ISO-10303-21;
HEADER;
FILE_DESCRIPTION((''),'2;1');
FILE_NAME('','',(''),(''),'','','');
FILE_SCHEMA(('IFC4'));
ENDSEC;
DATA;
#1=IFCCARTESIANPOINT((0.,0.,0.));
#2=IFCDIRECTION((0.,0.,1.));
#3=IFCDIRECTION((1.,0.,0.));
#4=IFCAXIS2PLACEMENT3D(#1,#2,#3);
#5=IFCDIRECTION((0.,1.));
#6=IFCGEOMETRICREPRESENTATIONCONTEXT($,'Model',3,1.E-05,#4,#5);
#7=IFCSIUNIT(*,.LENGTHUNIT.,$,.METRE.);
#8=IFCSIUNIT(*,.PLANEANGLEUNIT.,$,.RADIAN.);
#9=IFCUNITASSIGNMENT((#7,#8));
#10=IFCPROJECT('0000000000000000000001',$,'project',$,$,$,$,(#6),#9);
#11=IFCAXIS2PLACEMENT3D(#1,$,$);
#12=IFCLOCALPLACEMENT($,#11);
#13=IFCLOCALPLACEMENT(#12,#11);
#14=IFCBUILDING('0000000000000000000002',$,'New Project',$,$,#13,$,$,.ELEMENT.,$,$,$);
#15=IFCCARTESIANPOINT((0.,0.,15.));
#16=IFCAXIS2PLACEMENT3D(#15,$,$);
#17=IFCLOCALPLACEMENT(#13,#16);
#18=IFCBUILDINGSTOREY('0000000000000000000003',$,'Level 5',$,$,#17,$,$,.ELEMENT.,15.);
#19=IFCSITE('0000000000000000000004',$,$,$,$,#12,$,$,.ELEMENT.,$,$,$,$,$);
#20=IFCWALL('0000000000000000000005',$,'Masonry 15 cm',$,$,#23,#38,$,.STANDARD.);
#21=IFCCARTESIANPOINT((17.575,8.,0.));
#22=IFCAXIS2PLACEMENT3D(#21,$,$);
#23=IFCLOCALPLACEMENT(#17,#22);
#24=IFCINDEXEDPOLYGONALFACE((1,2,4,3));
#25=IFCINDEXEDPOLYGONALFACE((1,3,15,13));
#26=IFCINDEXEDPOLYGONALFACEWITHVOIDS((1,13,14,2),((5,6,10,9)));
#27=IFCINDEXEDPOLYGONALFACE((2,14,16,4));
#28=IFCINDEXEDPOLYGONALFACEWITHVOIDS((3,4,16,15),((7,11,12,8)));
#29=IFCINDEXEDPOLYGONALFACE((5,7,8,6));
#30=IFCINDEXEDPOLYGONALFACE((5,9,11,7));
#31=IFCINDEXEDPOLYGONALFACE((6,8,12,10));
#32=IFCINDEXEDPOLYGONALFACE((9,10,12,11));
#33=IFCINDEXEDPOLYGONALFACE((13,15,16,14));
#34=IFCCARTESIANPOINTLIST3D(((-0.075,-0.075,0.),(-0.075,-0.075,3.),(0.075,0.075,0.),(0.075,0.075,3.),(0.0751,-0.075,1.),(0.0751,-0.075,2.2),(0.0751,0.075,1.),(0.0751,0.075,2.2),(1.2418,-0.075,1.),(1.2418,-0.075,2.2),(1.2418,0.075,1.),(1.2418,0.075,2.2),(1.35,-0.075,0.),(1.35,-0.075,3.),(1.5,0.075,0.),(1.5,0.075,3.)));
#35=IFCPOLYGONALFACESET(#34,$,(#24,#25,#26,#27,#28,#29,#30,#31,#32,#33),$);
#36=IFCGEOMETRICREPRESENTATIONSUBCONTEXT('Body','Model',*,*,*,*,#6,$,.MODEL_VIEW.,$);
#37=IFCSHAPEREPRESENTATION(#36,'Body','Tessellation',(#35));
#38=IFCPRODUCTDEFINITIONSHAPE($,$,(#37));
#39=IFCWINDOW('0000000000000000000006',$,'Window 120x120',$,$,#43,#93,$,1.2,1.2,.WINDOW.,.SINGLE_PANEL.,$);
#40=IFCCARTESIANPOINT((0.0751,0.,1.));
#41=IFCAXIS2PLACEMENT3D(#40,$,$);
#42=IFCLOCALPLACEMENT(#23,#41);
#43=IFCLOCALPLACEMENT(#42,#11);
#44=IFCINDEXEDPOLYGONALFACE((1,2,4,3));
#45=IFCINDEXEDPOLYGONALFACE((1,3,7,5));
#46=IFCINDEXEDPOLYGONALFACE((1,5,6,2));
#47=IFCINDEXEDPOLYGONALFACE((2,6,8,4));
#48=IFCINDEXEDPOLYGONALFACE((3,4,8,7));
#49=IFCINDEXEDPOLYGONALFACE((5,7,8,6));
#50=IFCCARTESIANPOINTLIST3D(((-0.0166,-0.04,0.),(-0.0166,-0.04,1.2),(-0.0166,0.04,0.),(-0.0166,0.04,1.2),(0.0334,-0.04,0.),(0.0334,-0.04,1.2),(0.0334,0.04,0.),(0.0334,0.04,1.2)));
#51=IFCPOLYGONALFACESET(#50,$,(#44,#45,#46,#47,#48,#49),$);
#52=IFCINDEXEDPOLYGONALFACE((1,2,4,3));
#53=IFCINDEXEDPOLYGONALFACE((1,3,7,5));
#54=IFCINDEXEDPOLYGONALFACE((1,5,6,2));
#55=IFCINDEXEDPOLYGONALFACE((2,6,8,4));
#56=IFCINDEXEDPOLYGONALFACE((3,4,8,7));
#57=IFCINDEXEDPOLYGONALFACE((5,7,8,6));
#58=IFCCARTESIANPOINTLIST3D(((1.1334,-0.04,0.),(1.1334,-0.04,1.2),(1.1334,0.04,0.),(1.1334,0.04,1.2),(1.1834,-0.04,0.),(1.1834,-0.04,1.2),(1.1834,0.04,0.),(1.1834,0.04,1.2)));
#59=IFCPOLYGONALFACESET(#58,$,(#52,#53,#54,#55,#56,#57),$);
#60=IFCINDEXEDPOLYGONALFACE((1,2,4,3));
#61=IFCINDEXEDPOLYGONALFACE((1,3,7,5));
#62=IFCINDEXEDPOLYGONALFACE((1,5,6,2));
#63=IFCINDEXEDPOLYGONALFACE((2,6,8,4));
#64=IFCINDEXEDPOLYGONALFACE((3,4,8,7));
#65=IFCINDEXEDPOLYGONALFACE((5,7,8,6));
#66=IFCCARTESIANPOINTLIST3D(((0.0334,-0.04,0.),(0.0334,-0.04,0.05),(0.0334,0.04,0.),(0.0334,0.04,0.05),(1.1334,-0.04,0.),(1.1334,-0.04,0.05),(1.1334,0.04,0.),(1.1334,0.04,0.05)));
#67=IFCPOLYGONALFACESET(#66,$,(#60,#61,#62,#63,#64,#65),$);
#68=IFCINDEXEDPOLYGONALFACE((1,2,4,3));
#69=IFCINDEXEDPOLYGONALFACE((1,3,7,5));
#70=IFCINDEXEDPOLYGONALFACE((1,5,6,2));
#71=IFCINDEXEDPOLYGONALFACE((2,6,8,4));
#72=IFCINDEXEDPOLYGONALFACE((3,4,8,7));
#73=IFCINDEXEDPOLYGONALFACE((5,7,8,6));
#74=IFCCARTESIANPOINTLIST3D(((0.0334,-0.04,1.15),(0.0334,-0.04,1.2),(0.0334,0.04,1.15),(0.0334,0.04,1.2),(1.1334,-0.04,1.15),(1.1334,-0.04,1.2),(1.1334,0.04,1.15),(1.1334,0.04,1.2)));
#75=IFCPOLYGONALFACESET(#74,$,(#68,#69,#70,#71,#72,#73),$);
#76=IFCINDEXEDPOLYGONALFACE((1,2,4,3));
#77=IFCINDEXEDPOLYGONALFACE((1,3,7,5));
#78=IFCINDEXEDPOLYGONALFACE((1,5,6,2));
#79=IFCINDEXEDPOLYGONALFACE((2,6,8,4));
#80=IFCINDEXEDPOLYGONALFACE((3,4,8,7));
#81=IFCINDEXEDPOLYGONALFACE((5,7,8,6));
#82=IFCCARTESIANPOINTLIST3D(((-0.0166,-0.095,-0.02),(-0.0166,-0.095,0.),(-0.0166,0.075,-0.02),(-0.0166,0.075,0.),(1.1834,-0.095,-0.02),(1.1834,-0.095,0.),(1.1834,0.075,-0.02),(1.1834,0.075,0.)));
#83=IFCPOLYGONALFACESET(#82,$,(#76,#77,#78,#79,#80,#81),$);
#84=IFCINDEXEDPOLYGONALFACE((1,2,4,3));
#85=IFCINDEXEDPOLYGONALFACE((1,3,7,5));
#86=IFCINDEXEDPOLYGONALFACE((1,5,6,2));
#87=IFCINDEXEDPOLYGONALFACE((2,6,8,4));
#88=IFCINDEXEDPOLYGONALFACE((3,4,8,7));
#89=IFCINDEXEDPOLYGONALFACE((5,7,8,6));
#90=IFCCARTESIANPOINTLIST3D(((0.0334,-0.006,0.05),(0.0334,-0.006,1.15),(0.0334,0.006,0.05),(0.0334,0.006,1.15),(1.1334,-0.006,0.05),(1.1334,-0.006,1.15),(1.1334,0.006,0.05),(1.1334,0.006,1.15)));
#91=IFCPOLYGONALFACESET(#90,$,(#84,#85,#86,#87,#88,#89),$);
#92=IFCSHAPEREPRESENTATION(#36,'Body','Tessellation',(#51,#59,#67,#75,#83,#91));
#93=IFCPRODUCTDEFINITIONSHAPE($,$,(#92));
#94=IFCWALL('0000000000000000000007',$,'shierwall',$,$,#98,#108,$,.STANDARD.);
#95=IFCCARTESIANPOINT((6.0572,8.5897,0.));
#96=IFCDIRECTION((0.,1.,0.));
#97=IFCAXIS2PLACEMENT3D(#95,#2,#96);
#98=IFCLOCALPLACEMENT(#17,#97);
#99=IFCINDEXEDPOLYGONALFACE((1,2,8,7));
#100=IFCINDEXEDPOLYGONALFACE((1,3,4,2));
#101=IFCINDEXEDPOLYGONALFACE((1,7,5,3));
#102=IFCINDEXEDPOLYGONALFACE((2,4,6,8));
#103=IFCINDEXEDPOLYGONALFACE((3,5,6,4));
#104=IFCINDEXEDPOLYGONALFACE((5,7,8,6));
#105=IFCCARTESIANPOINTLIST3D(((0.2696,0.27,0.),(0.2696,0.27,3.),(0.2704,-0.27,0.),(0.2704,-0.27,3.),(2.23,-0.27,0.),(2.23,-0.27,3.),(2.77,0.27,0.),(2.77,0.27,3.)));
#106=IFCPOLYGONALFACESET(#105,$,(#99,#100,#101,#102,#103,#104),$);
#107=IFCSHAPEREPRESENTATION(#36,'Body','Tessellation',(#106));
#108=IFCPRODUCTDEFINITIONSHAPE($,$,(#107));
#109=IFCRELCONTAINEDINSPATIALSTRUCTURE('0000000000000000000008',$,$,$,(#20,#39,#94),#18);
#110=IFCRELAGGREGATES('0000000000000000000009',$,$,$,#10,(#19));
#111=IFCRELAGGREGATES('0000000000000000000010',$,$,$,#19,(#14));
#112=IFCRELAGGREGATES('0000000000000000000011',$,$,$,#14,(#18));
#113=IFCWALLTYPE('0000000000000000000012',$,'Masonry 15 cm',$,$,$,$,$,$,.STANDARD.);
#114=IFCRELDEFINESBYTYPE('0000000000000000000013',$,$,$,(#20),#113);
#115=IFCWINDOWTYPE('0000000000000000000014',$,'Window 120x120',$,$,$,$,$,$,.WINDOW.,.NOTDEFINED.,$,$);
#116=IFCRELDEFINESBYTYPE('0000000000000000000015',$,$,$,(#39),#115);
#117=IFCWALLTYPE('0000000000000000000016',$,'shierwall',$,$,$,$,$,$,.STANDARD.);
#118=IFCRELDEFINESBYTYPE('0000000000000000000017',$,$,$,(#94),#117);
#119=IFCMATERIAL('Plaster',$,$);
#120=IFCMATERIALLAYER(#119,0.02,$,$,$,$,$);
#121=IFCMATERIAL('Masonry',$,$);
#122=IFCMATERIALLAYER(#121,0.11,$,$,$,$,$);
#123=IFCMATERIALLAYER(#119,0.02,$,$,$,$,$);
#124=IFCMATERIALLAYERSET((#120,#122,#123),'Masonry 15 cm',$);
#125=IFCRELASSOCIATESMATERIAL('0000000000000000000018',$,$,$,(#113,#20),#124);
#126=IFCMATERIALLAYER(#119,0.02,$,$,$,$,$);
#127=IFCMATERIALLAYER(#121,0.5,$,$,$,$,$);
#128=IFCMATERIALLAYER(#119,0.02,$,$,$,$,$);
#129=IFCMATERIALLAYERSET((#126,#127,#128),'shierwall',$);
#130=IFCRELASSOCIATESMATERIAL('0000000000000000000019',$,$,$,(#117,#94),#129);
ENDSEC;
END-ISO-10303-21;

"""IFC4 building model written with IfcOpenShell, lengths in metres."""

from ifc_helpers import new_model, si_unit, direction, frame, frame_2d, origin, origin_with_axes, place, context, subcontext, project, spatial, polyline, rectangle, outline, extrude, material, layer, layer_set, layer_usage, type_object, element, fill, save


model = new_model("IFC4")

# Units and contexts
model_context = context("Model", 3, precision=1e-05, world=origin_with_axes(), true_north=direction((0.0, 1.0)))
body_context = subcontext(model_context, "Body", "Model", "MODEL_VIEW")
ifc_project = project(units=[si_unit("LENGTHUNIT", "METRE"), si_unit("PLANEANGLEUNIT", "RADIAN")], contexts=[model_context])

# Site, building, storey
site_placement = place(None, origin())
site = spatial("IfcSite", under=ifc_project, at=site_placement, CompositionType="ELEMENT")
building_placement = place(site_placement, origin())
building = spatial("IfcBuilding", under=site, at=building_placement, Name="New Project", CompositionType="ELEMENT")
storey_placement = place(building_placement, frame((0.0, 0.0, 15.0)))
storey = spatial("IfcBuildingStorey", under=building, at=storey_placement, Name="Level 5", CompositionType="ELEMENT", Elevation=15.0)

# Shared definitions
ifc_material_1 = material(Name="Plaster")
ifc_layer_1 = layer(ifc_material_1, 0.02)
ifc_material_2 = material(Name="Masonry")
ifc_layer_2 = layer(ifc_material_2, 0.11)
ifc_layer_3 = layer(ifc_material_1, 0.02)
ifc_layer_set_1 = layer_set([ifc_layer_1, ifc_layer_2, ifc_layer_3], Name="Masonry 15 cm")
ifc_layer_usage_1 = layer_usage(ifc_layer_set_1, "AXIS2", "NEGATIVE", 0.075)
wall_type_1 = type_object("IfcWallType", Name="Masonry 15 cm", PredefinedType="STANDARD", material=ifc_layer_set_1)
window_type = type_object("IfcWindowType", Name="Window 120x120", PartitioningType="NOTDEFINED", PredefinedType="WINDOW")

# Wall, opening, window
wall_1_placement = place(storey_placement, frame((17.575, 8.0, 0.0)))
wall_1 = element("IfcWall", 1, at=wall_1_placement, inside=storey, type_object=wall_type_1, material=ifc_layer_usage_1, Name="Masonry 15 cm", PredefinedType="STANDARD", context=body_context, shape_type="SweptSolid", body=[
    extrude(outline(polyline([(-0.075, -0.075), (1.35, -0.075), (1.5, 0.075), (0.075, 0.075), (-0.075, -0.075)])), origin(), (0.0, 0.0, 1.0), 3.0),
])
opening_1_placement = place(wall_1_placement, frame((0.0751, 0.0, 1.0)))
opening_1 = element("IfcOpeningElement", 2, at=opening_1_placement, cuts=wall_1, PredefinedType="OPENING", context=body_context, shape_type="SweptSolid", body=[
    extrude(rectangle(XDim=1.1667, YDim=0.25, at=frame_2d((0.5834, 0.0))), origin(), (0.0, 0.0, 1.0), 1.2),
])
window_1_placement = place(opening_1_placement, origin())
window_1 = element("IfcWindow", 3, at=window_1_placement, inside=storey, type_object=window_type, Name="Window 120x120", OverallHeight=1.2, OverallWidth=1.2, PartitioningType="SINGLE_PANEL", PredefinedType="WINDOW", context=body_context, shape_type="SweptSolid", body=[
    extrude(outline(polyline([(-0.0166, -0.04), (0.0334, -0.04), (0.0334, 0.04), (-0.0166, 0.04), (-0.0166, -0.04)])), origin(), (0.0, 0.0, 1.0), 1.2),
    extrude(outline(polyline([(1.1334, -0.04), (1.1834, -0.04), (1.1834, 0.04), (1.1334, 0.04), (1.1334, -0.04)])), origin(), (0.0, 0.0, 1.0), 1.2),
    extrude(outline(polyline([(0.0334, -0.04), (1.1334, -0.04), (1.1334, 0.04), (0.0334, 0.04), (0.0334, -0.04)])), origin(), (0.0, 0.0, 1.0), 0.05),
    extrude(outline(polyline([(0.0334, -0.04), (1.1334, -0.04), (1.1334, 0.04), (0.0334, 0.04), (0.0334, -0.04)])), frame((0.0, 0.0, 1.15)), (0.0, 0.0, 1.0), 0.05),
    extrude(outline(polyline([(-0.0166, -0.095), (1.1834, -0.095), (1.1834, 0.075), (-0.0166, 0.075), (-0.0166, -0.095)])), frame((0.0, 0.0, -0.02)), (0.0, 0.0, 1.0), 0.02),
    extrude(outline(polyline([(0.0334, -0.006), (1.1334, -0.006), (1.1334, 0.006), (0.0334, 0.006), (0.0334, -0.006)])), frame((0.0, 0.0, 0.05)), (0.0, 0.0, 1.0), 1.1),
])
fill(opening_1, window_1)

# Shared definitions
ifc_layer_4 = layer(ifc_material_1, 0.02)
ifc_layer_5 = layer(ifc_material_2, 0.5)
ifc_layer_6 = layer(ifc_material_1, 0.02)
ifc_layer_set_2 = layer_set([ifc_layer_4, ifc_layer_5, ifc_layer_6], Name="shierwall")
ifc_layer_usage_2 = layer_usage(ifc_layer_set_2, "AXIS2", "NEGATIVE", 0.27)
wall_type_2 = type_object("IfcWallType", Name="shierwall", PredefinedType="STANDARD", material=ifc_layer_set_2)

# Wall
wall_2_placement = place(storey_placement, frame((6.0572, 8.5897, 0.0), z_axis=(0.0, 0.0, 1.0), x_axis=(0.0, 1.0, 0.0)))
element("IfcWall", 4, at=wall_2_placement, inside=storey, type_object=wall_type_2, material=ifc_layer_usage_2, Name="shierwall", PredefinedType="STANDARD", context=body_context, shape_type="SweptSolid", body=[
    extrude(outline(polyline([(0.2704, -0.27), (2.23, -0.27), (2.77, 0.27), (0.2696, 0.27), (0.2704, -0.27)])), origin(), (0.0, 0.0, 1.0), 3.0),
])

save(model, "model.ifc")
